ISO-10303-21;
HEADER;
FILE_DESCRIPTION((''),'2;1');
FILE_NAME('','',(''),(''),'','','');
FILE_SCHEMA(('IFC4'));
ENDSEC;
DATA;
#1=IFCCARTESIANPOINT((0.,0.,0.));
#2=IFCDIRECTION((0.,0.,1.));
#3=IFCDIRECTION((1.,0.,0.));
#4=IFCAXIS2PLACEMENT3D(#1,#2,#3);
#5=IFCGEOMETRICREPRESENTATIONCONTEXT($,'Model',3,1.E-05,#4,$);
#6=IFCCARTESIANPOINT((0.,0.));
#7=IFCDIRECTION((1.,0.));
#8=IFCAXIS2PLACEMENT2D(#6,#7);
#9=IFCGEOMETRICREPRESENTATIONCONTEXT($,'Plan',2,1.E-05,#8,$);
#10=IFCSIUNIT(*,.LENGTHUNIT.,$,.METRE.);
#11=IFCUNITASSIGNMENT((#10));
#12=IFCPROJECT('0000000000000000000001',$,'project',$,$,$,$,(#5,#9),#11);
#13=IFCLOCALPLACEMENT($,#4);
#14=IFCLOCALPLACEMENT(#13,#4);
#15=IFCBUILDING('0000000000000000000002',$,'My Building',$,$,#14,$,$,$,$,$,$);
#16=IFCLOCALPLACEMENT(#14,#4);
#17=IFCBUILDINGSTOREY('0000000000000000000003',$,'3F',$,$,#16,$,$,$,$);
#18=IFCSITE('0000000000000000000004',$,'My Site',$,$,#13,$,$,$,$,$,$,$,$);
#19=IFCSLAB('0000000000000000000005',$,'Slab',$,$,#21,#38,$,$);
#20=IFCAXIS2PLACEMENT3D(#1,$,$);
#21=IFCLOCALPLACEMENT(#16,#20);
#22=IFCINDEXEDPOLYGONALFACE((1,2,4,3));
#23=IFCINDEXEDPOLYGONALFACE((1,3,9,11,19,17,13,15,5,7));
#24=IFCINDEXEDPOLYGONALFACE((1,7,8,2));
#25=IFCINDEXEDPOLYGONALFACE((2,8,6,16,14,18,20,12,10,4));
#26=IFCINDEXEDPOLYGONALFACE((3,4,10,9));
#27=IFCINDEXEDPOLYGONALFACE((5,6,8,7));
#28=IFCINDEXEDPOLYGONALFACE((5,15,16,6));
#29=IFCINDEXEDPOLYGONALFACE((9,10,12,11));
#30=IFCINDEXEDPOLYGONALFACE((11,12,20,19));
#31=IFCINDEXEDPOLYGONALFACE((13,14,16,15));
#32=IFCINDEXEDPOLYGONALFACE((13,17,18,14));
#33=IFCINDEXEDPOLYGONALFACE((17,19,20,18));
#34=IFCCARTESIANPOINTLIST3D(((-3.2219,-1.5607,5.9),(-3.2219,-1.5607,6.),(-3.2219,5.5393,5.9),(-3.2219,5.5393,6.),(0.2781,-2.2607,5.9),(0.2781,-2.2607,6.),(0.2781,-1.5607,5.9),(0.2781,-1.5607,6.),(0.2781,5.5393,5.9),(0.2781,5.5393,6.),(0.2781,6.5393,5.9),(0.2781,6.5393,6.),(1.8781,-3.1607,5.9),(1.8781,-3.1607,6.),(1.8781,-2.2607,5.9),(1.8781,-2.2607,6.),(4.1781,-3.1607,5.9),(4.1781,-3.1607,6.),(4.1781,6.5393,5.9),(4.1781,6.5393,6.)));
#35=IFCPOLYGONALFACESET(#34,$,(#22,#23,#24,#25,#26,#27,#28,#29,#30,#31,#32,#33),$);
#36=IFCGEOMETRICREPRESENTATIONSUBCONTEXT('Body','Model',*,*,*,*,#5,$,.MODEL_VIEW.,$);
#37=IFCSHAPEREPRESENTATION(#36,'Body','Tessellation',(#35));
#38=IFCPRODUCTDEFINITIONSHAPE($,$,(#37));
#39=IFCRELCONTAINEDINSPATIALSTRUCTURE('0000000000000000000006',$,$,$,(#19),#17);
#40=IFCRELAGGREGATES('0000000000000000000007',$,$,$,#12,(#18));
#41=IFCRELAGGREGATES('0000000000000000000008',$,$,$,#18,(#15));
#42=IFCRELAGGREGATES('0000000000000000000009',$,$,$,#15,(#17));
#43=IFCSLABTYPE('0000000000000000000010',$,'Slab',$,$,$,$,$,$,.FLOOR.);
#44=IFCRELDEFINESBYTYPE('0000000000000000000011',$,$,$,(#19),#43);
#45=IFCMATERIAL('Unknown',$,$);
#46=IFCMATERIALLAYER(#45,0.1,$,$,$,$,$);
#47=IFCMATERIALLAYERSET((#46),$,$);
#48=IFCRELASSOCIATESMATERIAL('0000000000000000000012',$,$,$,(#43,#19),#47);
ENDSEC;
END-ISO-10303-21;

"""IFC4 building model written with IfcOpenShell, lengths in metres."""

from ifc_helpers import new_model, si_unit, frame, origin_with_axes, origin_2d_with_axis, place, context, subcontext, project, spatial, indexed_curve, outline, extrude, material, layer, layer_set, layer_usage, type_object, element, save


model = new_model("IFC4")

# Units and contexts
model_context = context("Model", 3, precision=1e-05, world=origin_with_axes())
plan_context = context("Plan", 2, precision=1e-05, world=origin_2d_with_axis())
body_context = subcontext(model_context, "Body", "Model", "MODEL_VIEW")
ifc_project = project(units=[si_unit("LENGTHUNIT", "METRE")], contexts=[model_context, plan_context])

# Site, building, storey
site_placement = place(None, origin_with_axes())
site = spatial("IfcSite", under=ifc_project, at=site_placement, Name="My Site")
building_placement = place(site_placement, origin_with_axes())
building = spatial("IfcBuilding", under=site, at=building_placement, Name="My Building")
storey_placement = place(building_placement, origin_with_axes())
storey = spatial("IfcBuildingStorey", under=building, at=storey_placement, Name="3F")

# Slab
ifc_material = material(Name="Unknown")
ifc_layer = layer(ifc_material, 0.1)
ifc_layer_set = layer_set([ifc_layer])
ifc_layer_usage = layer_usage(ifc_layer_set, "AXIS3", "POSITIVE", -0.1)
slab_type = type_object("IfcSlabType", Name="Slab", PredefinedType="FLOOR", material=ifc_layer_set)
slab_placement = place(storey_placement, frame((4.1781, -3.1607, 6.0), z_axis=(0.0, 0.0, 1.0), x_axis=(1.0, 0.0, 0.0)))
element("IfcSlab", 1, at=slab_placement, inside=storey, type_object=slab_type, material=ifc_layer_usage, Name="Slab", context=body_context, shape_type="SweptSolid", body=[
    extrude(outline(indexed_curve([(0.0, 0.0), (0.0, 9.7), (-3.9, 9.7), (-3.9, 8.7), (-7.4, 8.7), (-7.4, 1.6), (-3.9, 1.6), (-3.9, 0.9), (-2.3, 0.9), (-2.3, 0.0), (0.0, 0.0)])), frame((0.0, 0.0, -0.1), z_axis=(0.0, 0.0, 1.0), x_axis=(1.0, 0.0, 0.0)), (0.0, 0.0, 1.0), 0.1),
])

save(model, "model.ifc")
